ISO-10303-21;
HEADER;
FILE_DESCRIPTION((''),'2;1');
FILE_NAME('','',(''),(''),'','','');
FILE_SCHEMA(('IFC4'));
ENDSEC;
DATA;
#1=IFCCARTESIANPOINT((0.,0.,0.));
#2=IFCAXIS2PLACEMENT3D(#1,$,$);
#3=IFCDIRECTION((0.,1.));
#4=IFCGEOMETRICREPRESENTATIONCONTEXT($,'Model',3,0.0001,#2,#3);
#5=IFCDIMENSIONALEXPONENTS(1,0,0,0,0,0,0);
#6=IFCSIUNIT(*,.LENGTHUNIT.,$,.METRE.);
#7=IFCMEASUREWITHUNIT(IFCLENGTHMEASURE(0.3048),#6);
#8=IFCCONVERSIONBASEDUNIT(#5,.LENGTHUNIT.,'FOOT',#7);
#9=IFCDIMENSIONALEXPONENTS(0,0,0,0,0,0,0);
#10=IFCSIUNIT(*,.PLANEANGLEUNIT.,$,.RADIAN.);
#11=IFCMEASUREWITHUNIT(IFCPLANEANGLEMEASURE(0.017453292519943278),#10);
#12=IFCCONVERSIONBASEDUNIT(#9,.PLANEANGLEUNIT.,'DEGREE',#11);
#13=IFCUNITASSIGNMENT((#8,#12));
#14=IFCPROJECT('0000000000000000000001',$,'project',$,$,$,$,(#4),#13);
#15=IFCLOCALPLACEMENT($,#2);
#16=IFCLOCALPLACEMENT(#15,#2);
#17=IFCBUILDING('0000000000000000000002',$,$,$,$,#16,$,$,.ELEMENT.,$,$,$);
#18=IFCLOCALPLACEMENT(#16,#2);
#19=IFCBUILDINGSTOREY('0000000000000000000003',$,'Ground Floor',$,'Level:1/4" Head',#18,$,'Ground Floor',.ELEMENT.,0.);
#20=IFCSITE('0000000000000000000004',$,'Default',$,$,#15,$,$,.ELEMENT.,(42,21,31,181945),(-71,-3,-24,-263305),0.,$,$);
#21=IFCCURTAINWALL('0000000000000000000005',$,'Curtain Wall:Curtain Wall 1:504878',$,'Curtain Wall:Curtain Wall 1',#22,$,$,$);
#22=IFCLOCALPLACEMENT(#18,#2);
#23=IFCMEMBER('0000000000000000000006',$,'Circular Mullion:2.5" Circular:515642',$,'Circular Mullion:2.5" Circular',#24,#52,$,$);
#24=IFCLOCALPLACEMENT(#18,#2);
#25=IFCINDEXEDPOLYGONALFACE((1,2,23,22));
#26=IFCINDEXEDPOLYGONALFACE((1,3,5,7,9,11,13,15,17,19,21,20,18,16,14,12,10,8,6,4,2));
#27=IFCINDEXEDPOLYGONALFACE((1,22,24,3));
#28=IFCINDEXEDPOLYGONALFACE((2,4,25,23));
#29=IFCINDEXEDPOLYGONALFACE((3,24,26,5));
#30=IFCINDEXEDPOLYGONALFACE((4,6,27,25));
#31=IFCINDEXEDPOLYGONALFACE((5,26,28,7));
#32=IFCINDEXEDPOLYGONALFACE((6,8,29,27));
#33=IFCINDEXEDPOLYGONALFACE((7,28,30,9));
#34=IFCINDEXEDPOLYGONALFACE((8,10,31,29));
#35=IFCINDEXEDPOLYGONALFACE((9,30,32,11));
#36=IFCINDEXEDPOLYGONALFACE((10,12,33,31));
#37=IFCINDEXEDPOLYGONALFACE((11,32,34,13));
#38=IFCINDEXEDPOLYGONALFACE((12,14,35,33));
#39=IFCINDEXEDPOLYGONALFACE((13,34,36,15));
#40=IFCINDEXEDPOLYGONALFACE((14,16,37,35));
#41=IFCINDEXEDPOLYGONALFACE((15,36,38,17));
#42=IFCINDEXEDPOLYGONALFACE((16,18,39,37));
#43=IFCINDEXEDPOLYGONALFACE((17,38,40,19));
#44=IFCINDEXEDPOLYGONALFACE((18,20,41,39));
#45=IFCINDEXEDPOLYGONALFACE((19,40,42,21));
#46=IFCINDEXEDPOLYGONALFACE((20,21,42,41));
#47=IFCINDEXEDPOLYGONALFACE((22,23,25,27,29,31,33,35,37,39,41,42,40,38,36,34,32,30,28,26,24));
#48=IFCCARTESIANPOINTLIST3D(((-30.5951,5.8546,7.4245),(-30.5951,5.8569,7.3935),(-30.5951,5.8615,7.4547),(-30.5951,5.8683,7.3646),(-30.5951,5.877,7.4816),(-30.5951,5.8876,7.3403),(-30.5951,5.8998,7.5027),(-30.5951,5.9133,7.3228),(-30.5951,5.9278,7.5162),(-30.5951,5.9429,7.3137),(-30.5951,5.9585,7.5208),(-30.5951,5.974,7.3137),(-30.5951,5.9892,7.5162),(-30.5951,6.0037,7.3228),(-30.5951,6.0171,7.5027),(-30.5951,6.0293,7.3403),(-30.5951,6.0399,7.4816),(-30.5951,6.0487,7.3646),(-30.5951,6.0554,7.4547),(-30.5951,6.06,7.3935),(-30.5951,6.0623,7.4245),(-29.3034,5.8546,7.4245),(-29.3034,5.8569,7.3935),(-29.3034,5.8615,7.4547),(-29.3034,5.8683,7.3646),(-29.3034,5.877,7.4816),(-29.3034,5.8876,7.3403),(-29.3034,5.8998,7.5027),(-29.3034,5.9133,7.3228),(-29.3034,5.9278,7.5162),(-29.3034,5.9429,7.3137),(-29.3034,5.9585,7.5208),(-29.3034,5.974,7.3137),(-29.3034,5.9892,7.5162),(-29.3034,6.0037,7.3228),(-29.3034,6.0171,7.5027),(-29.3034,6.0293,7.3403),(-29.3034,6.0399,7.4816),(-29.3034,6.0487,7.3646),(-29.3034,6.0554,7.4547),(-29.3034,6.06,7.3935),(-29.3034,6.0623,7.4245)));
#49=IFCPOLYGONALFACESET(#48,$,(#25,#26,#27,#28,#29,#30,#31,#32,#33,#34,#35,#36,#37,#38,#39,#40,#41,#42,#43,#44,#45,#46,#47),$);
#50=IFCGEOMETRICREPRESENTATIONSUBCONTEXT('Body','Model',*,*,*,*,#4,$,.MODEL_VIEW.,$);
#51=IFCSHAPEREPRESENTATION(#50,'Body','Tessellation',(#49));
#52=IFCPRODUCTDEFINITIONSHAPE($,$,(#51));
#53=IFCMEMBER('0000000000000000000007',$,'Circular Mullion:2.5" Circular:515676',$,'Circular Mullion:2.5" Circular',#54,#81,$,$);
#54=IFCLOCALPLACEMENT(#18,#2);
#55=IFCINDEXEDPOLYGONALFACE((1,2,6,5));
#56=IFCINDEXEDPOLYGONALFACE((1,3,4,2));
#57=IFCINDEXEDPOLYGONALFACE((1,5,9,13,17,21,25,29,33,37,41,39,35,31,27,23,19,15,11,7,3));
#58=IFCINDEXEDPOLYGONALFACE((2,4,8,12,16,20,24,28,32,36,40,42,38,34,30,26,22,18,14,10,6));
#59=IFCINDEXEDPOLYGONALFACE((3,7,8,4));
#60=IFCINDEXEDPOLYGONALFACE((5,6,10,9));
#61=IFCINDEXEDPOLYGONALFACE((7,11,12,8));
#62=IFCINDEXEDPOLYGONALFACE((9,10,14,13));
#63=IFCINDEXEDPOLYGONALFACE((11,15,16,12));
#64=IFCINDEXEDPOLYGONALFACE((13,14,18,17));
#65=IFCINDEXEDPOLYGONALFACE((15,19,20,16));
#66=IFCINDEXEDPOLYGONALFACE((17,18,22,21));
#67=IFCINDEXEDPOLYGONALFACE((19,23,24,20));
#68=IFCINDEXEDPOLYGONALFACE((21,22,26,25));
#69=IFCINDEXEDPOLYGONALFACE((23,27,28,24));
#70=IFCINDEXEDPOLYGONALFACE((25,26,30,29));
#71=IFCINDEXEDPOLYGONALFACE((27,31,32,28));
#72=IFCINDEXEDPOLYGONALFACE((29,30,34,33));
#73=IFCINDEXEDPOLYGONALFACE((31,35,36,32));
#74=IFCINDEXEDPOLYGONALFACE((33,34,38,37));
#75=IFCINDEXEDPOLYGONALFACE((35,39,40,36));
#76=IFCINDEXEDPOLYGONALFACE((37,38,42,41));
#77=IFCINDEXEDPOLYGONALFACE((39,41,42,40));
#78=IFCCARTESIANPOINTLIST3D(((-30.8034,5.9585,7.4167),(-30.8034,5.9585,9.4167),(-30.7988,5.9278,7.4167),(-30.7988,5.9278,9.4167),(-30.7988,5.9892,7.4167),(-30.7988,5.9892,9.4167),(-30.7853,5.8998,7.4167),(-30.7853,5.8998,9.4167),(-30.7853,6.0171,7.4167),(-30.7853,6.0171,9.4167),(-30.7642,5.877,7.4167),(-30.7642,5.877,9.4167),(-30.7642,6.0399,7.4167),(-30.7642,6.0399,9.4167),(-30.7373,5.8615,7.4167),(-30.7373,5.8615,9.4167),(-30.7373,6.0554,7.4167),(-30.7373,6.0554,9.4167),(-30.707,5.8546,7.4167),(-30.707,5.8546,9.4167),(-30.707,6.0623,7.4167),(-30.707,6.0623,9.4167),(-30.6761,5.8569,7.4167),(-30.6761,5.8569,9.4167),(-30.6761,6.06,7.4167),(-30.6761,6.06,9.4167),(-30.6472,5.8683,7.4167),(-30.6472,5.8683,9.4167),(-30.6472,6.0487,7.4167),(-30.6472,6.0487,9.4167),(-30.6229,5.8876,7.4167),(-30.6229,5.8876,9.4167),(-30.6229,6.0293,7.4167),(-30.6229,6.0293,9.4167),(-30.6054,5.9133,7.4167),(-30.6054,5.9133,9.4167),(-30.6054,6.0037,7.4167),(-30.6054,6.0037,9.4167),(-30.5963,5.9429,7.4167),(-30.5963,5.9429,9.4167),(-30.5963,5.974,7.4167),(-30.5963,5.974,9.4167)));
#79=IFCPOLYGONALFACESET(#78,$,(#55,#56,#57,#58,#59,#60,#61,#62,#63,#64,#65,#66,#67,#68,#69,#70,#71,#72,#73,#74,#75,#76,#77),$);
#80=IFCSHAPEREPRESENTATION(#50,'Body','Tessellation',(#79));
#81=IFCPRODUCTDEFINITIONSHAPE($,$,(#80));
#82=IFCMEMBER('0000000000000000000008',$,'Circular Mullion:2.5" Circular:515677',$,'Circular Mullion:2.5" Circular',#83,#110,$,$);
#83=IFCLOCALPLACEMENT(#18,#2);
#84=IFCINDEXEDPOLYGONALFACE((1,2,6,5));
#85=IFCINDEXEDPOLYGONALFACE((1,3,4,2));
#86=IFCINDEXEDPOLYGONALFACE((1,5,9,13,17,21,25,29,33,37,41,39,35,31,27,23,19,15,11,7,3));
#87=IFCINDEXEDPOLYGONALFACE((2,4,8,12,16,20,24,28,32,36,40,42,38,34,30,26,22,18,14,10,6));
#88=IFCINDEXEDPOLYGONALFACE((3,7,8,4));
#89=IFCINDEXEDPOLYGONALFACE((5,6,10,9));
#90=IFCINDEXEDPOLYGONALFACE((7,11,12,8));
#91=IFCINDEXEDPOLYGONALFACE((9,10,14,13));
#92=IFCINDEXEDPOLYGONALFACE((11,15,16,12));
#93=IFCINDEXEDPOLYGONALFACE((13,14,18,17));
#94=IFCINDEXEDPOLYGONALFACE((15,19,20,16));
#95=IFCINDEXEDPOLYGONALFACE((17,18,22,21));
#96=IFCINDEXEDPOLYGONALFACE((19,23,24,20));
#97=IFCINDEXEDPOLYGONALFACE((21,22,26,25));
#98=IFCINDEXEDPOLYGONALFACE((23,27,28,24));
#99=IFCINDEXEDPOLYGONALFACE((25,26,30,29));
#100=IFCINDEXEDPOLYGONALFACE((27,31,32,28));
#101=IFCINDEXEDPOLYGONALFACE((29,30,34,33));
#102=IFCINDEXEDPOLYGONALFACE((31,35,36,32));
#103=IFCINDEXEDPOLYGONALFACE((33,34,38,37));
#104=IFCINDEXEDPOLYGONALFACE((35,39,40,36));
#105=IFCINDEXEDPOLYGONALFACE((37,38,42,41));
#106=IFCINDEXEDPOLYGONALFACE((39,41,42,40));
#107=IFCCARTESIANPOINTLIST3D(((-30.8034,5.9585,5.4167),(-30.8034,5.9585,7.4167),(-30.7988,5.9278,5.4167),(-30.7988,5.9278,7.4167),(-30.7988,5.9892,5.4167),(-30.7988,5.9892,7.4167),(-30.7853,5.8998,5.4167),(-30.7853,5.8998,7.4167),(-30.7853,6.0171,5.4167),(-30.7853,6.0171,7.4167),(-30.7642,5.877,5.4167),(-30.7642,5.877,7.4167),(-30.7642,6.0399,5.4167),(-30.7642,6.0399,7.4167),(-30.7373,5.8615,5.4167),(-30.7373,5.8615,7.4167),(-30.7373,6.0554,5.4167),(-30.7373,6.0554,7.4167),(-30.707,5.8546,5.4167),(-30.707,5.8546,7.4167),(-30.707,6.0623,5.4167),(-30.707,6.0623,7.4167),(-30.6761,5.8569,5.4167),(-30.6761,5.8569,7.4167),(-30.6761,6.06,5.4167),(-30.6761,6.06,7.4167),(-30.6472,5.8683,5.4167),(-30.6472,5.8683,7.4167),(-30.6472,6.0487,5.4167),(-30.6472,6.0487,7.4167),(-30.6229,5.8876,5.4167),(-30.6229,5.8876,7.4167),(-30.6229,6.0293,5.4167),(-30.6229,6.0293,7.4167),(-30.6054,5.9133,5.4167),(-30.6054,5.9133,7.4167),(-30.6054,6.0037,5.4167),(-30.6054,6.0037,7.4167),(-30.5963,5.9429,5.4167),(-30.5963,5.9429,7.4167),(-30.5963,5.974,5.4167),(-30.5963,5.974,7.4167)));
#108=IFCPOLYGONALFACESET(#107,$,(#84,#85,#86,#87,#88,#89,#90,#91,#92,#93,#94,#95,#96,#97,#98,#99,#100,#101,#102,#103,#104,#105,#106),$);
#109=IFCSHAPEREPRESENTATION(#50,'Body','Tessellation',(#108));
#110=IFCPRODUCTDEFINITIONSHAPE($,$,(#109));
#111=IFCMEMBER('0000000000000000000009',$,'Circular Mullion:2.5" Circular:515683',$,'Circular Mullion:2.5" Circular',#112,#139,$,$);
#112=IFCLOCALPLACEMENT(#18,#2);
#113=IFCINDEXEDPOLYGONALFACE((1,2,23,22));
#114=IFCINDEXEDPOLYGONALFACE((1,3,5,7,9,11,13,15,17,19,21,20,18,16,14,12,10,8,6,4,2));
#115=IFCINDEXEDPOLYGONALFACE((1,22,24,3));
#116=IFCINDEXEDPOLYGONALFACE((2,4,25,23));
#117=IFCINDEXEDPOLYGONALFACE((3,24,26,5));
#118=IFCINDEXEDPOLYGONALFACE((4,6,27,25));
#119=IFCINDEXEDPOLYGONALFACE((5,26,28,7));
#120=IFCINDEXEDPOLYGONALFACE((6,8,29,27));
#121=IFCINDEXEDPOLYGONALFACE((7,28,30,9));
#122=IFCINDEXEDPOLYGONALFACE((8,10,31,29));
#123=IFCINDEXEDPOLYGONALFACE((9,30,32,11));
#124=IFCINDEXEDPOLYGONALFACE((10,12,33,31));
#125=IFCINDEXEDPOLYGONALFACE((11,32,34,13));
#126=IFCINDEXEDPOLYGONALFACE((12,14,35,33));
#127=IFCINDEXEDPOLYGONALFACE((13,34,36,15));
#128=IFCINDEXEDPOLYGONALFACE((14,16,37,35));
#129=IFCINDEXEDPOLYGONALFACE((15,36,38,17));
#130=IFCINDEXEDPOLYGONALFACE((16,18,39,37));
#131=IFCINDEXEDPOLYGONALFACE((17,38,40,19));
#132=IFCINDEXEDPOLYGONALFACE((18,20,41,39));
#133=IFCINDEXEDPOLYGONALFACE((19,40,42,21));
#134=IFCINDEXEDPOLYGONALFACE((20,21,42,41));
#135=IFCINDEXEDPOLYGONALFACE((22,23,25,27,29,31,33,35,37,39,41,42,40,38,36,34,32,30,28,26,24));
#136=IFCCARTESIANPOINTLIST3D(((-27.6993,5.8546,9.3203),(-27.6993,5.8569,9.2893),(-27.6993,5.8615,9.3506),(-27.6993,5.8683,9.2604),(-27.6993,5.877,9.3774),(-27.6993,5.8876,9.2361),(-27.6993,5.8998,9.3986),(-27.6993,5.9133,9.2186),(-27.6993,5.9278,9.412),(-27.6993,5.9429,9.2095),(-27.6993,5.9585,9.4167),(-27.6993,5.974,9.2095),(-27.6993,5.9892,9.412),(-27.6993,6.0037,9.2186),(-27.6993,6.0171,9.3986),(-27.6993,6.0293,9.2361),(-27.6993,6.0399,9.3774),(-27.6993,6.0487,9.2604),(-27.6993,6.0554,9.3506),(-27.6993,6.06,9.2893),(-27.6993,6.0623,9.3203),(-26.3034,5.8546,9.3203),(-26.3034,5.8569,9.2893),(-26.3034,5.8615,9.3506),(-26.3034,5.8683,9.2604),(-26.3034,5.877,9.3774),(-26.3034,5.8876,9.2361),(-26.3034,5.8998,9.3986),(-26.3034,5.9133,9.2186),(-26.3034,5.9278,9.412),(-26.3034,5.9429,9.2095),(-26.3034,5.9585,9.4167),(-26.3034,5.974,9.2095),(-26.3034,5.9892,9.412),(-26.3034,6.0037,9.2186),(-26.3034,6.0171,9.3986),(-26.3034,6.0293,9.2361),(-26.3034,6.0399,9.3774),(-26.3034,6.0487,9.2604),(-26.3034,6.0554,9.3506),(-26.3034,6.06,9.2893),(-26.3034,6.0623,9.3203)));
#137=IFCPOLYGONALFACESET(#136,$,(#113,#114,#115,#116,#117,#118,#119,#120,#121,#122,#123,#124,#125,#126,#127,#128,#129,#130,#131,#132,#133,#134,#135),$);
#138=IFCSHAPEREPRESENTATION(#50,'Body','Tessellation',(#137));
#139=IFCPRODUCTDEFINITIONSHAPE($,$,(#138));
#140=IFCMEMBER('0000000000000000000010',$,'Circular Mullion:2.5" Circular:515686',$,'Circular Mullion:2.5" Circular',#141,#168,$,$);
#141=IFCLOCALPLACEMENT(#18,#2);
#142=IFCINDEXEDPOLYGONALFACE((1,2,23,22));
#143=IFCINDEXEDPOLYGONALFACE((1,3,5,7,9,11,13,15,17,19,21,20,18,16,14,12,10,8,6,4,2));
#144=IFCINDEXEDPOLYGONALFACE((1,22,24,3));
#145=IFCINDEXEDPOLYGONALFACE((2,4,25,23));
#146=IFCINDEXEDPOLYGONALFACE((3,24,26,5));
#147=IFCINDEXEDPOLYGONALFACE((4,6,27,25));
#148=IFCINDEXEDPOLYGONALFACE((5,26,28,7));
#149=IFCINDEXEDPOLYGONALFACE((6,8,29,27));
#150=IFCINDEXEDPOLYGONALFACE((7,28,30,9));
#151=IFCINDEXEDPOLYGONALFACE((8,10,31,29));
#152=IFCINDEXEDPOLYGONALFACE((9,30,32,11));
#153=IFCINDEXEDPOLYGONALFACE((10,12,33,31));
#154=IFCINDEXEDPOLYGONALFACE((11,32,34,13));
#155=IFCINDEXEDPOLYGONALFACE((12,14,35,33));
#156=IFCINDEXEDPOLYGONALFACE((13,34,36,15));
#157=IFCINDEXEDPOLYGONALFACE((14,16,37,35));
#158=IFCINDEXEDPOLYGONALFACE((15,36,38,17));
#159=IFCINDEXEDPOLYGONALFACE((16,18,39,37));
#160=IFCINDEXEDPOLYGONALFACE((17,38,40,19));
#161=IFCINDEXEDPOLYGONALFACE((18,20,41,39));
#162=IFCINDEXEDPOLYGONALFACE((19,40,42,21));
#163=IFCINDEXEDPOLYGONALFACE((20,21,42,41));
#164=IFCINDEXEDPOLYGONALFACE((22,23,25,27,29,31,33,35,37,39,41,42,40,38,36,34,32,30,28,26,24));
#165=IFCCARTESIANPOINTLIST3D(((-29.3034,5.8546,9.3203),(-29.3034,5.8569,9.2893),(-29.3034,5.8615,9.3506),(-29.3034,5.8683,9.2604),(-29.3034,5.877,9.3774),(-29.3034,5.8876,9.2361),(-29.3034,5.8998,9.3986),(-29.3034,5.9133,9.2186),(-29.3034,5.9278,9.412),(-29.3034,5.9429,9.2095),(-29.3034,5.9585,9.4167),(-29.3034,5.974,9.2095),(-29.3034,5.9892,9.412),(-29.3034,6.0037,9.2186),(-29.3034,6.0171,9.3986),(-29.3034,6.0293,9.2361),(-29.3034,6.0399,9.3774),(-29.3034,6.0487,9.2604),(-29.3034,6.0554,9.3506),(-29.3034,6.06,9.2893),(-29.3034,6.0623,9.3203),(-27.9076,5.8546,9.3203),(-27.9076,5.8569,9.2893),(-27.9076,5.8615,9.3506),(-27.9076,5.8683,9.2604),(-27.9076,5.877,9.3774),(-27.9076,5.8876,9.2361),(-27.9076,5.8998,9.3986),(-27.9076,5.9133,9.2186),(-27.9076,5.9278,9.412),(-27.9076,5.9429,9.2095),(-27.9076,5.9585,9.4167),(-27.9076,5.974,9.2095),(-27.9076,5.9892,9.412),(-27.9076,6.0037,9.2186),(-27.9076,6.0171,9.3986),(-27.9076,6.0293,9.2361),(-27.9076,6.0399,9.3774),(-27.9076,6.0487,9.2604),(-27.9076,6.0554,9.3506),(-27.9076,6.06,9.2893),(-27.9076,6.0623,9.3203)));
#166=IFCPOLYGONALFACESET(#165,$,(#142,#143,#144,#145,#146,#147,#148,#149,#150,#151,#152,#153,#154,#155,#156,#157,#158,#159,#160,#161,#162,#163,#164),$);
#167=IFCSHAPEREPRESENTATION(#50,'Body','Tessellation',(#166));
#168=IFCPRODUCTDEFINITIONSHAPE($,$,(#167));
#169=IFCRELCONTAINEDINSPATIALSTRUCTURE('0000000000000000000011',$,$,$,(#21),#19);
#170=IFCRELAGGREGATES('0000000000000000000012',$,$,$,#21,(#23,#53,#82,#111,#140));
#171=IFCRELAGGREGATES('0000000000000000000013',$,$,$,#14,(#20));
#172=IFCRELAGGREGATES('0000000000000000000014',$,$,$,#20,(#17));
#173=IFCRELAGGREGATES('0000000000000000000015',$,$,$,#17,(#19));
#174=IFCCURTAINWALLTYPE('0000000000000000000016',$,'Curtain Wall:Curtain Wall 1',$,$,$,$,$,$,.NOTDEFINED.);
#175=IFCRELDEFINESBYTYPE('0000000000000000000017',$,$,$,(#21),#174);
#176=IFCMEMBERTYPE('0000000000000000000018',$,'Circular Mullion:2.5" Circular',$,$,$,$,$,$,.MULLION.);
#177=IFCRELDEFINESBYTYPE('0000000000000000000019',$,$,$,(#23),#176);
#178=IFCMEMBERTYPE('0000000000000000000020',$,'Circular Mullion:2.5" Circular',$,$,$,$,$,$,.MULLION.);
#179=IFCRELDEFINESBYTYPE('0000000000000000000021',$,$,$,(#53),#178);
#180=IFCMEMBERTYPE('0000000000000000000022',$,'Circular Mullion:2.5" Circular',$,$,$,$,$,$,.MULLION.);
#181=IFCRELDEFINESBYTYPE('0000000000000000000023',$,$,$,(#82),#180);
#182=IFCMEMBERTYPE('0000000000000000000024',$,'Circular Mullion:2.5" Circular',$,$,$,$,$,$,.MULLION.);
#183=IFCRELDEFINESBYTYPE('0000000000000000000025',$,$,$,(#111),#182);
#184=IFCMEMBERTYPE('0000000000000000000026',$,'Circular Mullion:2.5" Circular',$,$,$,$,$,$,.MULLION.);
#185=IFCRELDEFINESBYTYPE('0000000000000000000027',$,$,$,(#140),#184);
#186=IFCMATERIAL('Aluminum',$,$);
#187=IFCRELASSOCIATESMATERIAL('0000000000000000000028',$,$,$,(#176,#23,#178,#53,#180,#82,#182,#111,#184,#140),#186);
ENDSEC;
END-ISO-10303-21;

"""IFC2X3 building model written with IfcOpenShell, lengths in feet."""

from ifc_helpers import new_model, entity, si_unit, converted_unit, direction, frame, frame_2d, origin, place, context, subcontext, project, spatial, circle, extrude, source, transform, mapped, material, type_object, type_shapes, element, aggregate, save


model = new_model("IFC2X3")

# Units and contexts
model_context = context("Model", 3, precision=0.0001, world=origin(), true_north=direction((0.0, 1.0)))
body_context = subcontext(model_context, "Body", "Model", "MODEL_VIEW")
ifc_project = project(units=[converted_unit("LENGTHUNIT", "FOOT", entity("IfcLengthMeasure", 0.3048), si_unit("LENGTHUNIT", "METRE"), dimensions=[1, 0, 0, 0, 0, 0, 0]), converted_unit("PLANEANGLEUNIT", "DEGREE", entity("IfcPlaneAngleMeasure", 0.017453292519943278), si_unit("PLANEANGLEUNIT", "RADIAN"), dimensions=[0, 0, 0, 0, 0, 0, 0])], contexts=[model_context])

# Site, building, storey
site_placement = place(None, origin())
site = spatial("IfcSite", under=ifc_project, at=site_placement, Name="Default", CompositionType="ELEMENT", RefLatitude=(42, 21, 31, 181945), RefLongitude=(-71, -3, -24, -263305), RefElevation=0.0)
building_placement = place(site_placement, origin())
building = spatial("IfcBuilding", under=site, at=building_placement, CompositionType="ELEMENT")
storey_placement = place(building_placement, origin())
storey = spatial("IfcBuildingStorey", under=building, at=storey_placement, Name="Ground Floor", ObjectType="Level:1/4\" Head", LongName="Ground Floor", CompositionType="ELEMENT", Elevation=0.0)

# Curtain wall, members
curtain_wall_type = type_object("IfcCurtainWallType", Name="Curtain Wall:Curtain Wall 1", PredefinedType="NOTDEFINED")
curtain_wall_placement = place(storey_placement, origin())
curtain_wall = element("IfcCurtainWall", 1, at=curtain_wall_placement, inside=storey, type_object=curtain_wall_type, Name="Curtain Wall:Curtain Wall 1:504878", ObjectType="Curtain Wall:Curtain Wall 1")
ifc_material_1 = material(Name="Aluminum")
member_type_1 = type_object("IfcMemberType", Name="Circular Mullion:2.5\" Circular", PredefinedType="MULLION", material=ifc_material_1)
shared_shape_1 = source(origin(), body_context, "Body", "SweptSolid", [
    extrude(circle(Radius=0.1042, at=frame_2d((0.0, 0.0), x_axis=(1.0, 0.0))), frame((0.0, 0.0, -1.2917)), (0.0, 0.0, 1.0), 1.2917),
])
type_shapes(member_type_1, [shared_shape_1])
member_1_placement = place(curtain_wall_placement, frame((-30.5951, 5.9585, 7.4167), z_axis=(-1.0, 0.0, 0.0), x_axis=(0.0, 0.0, 1.0)))
member_1 = element("IfcMember", 2, at=member_1_placement, type_object=member_type_1, material=ifc_material_1, Name="Circular Mullion:2.5\" Circular:515642", ObjectType="Circular Mullion:2.5\" Circular", context=body_context, shape_type="MappedRepresentation", body=[
    mapped(shared_shape_1, transform((0.0, 0.0, 0.0), scale=1.0)),
])
member_type_2 = type_object("IfcMemberType", Name="Circular Mullion:2.5\" Circular", PredefinedType="MULLION", material=ifc_material_1)
shared_shape_2 = source(origin(), body_context, "Body", "SweptSolid", [
    extrude(circle(Radius=0.1042, at=frame_2d((0.0, 0.0), x_axis=(1.0, 0.0))), frame((-0.1042, 0.0, -2.0)), (0.0, 0.0, 1.0), 2.0),
])
type_shapes(member_type_2, [shared_shape_2])
member_2_placement = place(curtain_wall_placement, frame((-30.8034, 5.9585, 7.4167), z_axis=(0.0, 0.0, -1.0), x_axis=(-1.0, 0.0, 0.0)))
member_2 = element("IfcMember", 3, at=member_2_placement, type_object=member_type_2, material=ifc_material_1, Name="Circular Mullion:2.5\" Circular:515676", ObjectType="Circular Mullion:2.5\" Circular", context=body_context, shape_type="MappedRepresentation", body=[
    mapped(shared_shape_2, transform((0.0, 0.0, 0.0), scale=1.0)),
])
member_type_3 = type_object("IfcMemberType", Name="Circular Mullion:2.5\" Circular", PredefinedType="MULLION", material=ifc_material_1)
shared_shape_3 = source(origin(), body_context, "Body", "SweptSolid", [
    extrude(circle(Radius=0.1042, at=frame_2d((0.0, 0.0), x_axis=(1.0, 0.0))), frame((-0.1042, 0.0, -2.0)), (0.0, 0.0, 1.0), 2.0),
])
type_shapes(member_type_3, [shared_shape_3])
member_3_placement = place(curtain_wall_placement, frame((-30.8034, 5.9585, 5.4167), z_axis=(0.0, 0.0, -1.0), x_axis=(-1.0, 0.0, 0.0)))
member_3 = element("IfcMember", 4, at=member_3_placement, type_object=member_type_3, material=ifc_material_1, Name="Circular Mullion:2.5\" Circular:515677", ObjectType="Circular Mullion:2.5\" Circular", context=body_context, shape_type="MappedRepresentation", body=[
    mapped(shared_shape_3, transform((0.0, 0.0, 0.0), scale=1.0)),
])
member_type_4 = type_object("IfcMemberType", Name="Circular Mullion:2.5\" Circular", PredefinedType="MULLION", material=ifc_material_1)
shared_shape_4 = source(origin(), body_context, "Body", "SweptSolid", [
    extrude(circle(Radius=0.1042, at=frame_2d((0.0, 0.0), x_axis=(1.0, 0.0))), frame((-0.1042, 0.0, -1.3958)), (0.0, 0.0, 1.0), 1.3958),
])
type_shapes(member_type_4, [shared_shape_4])
member_4_placement = place(curtain_wall_placement, frame((-27.6993, 5.9585, 9.4167), z_axis=(-1.0, 0.0, 0.0), x_axis=(0.0, 0.0, 1.0)))
member_4 = element("IfcMember", 5, at=member_4_placement, type_object=member_type_4, material=ifc_material_1, Name="Circular Mullion:2.5\" Circular:515683", ObjectType="Circular Mullion:2.5\" Circular", context=body_context, shape_type="MappedRepresentation", body=[
    mapped(shared_shape_4, transform((0.0, 0.0, 0.0), scale=1.0)),
])
member_type_5 = type_object("IfcMemberType", Name="Circular Mullion:2.5\" Circular", PredefinedType="MULLION", material=ifc_material_1)
shared_shape_5 = source(origin(), body_context, "Body", "SweptSolid", [
    extrude(circle(Radius=0.1042, at=frame_2d((0.0, 0.0), x_axis=(1.0, 0.0))), frame((-0.1042, 0.0, -1.3958)), (0.0, 0.0, 1.0), 1.3958),
])
type_shapes(member_type_5, [shared_shape_5])
member_5_placement = place(curtain_wall_placement, frame((-29.3034, 5.9585, 9.4167), z_axis=(-1.0, 0.0, 0.0), x_axis=(0.0, 0.0, 1.0)))
member_5 = element("IfcMember", 6, at=member_5_placement, type_object=member_type_5, material=ifc_material_1, Name="Circular Mullion:2.5\" Circular:515686", ObjectType="Circular Mullion:2.5\" Circular", context=body_context, shape_type="MappedRepresentation", body=[
    mapped(shared_shape_5, transform((0.0, 0.0, 0.0), scale=1.0)),
])
aggregate(curtain_wall, [member_1, member_2, member_3, member_4, member_5])

save(model, "model.ifc")
